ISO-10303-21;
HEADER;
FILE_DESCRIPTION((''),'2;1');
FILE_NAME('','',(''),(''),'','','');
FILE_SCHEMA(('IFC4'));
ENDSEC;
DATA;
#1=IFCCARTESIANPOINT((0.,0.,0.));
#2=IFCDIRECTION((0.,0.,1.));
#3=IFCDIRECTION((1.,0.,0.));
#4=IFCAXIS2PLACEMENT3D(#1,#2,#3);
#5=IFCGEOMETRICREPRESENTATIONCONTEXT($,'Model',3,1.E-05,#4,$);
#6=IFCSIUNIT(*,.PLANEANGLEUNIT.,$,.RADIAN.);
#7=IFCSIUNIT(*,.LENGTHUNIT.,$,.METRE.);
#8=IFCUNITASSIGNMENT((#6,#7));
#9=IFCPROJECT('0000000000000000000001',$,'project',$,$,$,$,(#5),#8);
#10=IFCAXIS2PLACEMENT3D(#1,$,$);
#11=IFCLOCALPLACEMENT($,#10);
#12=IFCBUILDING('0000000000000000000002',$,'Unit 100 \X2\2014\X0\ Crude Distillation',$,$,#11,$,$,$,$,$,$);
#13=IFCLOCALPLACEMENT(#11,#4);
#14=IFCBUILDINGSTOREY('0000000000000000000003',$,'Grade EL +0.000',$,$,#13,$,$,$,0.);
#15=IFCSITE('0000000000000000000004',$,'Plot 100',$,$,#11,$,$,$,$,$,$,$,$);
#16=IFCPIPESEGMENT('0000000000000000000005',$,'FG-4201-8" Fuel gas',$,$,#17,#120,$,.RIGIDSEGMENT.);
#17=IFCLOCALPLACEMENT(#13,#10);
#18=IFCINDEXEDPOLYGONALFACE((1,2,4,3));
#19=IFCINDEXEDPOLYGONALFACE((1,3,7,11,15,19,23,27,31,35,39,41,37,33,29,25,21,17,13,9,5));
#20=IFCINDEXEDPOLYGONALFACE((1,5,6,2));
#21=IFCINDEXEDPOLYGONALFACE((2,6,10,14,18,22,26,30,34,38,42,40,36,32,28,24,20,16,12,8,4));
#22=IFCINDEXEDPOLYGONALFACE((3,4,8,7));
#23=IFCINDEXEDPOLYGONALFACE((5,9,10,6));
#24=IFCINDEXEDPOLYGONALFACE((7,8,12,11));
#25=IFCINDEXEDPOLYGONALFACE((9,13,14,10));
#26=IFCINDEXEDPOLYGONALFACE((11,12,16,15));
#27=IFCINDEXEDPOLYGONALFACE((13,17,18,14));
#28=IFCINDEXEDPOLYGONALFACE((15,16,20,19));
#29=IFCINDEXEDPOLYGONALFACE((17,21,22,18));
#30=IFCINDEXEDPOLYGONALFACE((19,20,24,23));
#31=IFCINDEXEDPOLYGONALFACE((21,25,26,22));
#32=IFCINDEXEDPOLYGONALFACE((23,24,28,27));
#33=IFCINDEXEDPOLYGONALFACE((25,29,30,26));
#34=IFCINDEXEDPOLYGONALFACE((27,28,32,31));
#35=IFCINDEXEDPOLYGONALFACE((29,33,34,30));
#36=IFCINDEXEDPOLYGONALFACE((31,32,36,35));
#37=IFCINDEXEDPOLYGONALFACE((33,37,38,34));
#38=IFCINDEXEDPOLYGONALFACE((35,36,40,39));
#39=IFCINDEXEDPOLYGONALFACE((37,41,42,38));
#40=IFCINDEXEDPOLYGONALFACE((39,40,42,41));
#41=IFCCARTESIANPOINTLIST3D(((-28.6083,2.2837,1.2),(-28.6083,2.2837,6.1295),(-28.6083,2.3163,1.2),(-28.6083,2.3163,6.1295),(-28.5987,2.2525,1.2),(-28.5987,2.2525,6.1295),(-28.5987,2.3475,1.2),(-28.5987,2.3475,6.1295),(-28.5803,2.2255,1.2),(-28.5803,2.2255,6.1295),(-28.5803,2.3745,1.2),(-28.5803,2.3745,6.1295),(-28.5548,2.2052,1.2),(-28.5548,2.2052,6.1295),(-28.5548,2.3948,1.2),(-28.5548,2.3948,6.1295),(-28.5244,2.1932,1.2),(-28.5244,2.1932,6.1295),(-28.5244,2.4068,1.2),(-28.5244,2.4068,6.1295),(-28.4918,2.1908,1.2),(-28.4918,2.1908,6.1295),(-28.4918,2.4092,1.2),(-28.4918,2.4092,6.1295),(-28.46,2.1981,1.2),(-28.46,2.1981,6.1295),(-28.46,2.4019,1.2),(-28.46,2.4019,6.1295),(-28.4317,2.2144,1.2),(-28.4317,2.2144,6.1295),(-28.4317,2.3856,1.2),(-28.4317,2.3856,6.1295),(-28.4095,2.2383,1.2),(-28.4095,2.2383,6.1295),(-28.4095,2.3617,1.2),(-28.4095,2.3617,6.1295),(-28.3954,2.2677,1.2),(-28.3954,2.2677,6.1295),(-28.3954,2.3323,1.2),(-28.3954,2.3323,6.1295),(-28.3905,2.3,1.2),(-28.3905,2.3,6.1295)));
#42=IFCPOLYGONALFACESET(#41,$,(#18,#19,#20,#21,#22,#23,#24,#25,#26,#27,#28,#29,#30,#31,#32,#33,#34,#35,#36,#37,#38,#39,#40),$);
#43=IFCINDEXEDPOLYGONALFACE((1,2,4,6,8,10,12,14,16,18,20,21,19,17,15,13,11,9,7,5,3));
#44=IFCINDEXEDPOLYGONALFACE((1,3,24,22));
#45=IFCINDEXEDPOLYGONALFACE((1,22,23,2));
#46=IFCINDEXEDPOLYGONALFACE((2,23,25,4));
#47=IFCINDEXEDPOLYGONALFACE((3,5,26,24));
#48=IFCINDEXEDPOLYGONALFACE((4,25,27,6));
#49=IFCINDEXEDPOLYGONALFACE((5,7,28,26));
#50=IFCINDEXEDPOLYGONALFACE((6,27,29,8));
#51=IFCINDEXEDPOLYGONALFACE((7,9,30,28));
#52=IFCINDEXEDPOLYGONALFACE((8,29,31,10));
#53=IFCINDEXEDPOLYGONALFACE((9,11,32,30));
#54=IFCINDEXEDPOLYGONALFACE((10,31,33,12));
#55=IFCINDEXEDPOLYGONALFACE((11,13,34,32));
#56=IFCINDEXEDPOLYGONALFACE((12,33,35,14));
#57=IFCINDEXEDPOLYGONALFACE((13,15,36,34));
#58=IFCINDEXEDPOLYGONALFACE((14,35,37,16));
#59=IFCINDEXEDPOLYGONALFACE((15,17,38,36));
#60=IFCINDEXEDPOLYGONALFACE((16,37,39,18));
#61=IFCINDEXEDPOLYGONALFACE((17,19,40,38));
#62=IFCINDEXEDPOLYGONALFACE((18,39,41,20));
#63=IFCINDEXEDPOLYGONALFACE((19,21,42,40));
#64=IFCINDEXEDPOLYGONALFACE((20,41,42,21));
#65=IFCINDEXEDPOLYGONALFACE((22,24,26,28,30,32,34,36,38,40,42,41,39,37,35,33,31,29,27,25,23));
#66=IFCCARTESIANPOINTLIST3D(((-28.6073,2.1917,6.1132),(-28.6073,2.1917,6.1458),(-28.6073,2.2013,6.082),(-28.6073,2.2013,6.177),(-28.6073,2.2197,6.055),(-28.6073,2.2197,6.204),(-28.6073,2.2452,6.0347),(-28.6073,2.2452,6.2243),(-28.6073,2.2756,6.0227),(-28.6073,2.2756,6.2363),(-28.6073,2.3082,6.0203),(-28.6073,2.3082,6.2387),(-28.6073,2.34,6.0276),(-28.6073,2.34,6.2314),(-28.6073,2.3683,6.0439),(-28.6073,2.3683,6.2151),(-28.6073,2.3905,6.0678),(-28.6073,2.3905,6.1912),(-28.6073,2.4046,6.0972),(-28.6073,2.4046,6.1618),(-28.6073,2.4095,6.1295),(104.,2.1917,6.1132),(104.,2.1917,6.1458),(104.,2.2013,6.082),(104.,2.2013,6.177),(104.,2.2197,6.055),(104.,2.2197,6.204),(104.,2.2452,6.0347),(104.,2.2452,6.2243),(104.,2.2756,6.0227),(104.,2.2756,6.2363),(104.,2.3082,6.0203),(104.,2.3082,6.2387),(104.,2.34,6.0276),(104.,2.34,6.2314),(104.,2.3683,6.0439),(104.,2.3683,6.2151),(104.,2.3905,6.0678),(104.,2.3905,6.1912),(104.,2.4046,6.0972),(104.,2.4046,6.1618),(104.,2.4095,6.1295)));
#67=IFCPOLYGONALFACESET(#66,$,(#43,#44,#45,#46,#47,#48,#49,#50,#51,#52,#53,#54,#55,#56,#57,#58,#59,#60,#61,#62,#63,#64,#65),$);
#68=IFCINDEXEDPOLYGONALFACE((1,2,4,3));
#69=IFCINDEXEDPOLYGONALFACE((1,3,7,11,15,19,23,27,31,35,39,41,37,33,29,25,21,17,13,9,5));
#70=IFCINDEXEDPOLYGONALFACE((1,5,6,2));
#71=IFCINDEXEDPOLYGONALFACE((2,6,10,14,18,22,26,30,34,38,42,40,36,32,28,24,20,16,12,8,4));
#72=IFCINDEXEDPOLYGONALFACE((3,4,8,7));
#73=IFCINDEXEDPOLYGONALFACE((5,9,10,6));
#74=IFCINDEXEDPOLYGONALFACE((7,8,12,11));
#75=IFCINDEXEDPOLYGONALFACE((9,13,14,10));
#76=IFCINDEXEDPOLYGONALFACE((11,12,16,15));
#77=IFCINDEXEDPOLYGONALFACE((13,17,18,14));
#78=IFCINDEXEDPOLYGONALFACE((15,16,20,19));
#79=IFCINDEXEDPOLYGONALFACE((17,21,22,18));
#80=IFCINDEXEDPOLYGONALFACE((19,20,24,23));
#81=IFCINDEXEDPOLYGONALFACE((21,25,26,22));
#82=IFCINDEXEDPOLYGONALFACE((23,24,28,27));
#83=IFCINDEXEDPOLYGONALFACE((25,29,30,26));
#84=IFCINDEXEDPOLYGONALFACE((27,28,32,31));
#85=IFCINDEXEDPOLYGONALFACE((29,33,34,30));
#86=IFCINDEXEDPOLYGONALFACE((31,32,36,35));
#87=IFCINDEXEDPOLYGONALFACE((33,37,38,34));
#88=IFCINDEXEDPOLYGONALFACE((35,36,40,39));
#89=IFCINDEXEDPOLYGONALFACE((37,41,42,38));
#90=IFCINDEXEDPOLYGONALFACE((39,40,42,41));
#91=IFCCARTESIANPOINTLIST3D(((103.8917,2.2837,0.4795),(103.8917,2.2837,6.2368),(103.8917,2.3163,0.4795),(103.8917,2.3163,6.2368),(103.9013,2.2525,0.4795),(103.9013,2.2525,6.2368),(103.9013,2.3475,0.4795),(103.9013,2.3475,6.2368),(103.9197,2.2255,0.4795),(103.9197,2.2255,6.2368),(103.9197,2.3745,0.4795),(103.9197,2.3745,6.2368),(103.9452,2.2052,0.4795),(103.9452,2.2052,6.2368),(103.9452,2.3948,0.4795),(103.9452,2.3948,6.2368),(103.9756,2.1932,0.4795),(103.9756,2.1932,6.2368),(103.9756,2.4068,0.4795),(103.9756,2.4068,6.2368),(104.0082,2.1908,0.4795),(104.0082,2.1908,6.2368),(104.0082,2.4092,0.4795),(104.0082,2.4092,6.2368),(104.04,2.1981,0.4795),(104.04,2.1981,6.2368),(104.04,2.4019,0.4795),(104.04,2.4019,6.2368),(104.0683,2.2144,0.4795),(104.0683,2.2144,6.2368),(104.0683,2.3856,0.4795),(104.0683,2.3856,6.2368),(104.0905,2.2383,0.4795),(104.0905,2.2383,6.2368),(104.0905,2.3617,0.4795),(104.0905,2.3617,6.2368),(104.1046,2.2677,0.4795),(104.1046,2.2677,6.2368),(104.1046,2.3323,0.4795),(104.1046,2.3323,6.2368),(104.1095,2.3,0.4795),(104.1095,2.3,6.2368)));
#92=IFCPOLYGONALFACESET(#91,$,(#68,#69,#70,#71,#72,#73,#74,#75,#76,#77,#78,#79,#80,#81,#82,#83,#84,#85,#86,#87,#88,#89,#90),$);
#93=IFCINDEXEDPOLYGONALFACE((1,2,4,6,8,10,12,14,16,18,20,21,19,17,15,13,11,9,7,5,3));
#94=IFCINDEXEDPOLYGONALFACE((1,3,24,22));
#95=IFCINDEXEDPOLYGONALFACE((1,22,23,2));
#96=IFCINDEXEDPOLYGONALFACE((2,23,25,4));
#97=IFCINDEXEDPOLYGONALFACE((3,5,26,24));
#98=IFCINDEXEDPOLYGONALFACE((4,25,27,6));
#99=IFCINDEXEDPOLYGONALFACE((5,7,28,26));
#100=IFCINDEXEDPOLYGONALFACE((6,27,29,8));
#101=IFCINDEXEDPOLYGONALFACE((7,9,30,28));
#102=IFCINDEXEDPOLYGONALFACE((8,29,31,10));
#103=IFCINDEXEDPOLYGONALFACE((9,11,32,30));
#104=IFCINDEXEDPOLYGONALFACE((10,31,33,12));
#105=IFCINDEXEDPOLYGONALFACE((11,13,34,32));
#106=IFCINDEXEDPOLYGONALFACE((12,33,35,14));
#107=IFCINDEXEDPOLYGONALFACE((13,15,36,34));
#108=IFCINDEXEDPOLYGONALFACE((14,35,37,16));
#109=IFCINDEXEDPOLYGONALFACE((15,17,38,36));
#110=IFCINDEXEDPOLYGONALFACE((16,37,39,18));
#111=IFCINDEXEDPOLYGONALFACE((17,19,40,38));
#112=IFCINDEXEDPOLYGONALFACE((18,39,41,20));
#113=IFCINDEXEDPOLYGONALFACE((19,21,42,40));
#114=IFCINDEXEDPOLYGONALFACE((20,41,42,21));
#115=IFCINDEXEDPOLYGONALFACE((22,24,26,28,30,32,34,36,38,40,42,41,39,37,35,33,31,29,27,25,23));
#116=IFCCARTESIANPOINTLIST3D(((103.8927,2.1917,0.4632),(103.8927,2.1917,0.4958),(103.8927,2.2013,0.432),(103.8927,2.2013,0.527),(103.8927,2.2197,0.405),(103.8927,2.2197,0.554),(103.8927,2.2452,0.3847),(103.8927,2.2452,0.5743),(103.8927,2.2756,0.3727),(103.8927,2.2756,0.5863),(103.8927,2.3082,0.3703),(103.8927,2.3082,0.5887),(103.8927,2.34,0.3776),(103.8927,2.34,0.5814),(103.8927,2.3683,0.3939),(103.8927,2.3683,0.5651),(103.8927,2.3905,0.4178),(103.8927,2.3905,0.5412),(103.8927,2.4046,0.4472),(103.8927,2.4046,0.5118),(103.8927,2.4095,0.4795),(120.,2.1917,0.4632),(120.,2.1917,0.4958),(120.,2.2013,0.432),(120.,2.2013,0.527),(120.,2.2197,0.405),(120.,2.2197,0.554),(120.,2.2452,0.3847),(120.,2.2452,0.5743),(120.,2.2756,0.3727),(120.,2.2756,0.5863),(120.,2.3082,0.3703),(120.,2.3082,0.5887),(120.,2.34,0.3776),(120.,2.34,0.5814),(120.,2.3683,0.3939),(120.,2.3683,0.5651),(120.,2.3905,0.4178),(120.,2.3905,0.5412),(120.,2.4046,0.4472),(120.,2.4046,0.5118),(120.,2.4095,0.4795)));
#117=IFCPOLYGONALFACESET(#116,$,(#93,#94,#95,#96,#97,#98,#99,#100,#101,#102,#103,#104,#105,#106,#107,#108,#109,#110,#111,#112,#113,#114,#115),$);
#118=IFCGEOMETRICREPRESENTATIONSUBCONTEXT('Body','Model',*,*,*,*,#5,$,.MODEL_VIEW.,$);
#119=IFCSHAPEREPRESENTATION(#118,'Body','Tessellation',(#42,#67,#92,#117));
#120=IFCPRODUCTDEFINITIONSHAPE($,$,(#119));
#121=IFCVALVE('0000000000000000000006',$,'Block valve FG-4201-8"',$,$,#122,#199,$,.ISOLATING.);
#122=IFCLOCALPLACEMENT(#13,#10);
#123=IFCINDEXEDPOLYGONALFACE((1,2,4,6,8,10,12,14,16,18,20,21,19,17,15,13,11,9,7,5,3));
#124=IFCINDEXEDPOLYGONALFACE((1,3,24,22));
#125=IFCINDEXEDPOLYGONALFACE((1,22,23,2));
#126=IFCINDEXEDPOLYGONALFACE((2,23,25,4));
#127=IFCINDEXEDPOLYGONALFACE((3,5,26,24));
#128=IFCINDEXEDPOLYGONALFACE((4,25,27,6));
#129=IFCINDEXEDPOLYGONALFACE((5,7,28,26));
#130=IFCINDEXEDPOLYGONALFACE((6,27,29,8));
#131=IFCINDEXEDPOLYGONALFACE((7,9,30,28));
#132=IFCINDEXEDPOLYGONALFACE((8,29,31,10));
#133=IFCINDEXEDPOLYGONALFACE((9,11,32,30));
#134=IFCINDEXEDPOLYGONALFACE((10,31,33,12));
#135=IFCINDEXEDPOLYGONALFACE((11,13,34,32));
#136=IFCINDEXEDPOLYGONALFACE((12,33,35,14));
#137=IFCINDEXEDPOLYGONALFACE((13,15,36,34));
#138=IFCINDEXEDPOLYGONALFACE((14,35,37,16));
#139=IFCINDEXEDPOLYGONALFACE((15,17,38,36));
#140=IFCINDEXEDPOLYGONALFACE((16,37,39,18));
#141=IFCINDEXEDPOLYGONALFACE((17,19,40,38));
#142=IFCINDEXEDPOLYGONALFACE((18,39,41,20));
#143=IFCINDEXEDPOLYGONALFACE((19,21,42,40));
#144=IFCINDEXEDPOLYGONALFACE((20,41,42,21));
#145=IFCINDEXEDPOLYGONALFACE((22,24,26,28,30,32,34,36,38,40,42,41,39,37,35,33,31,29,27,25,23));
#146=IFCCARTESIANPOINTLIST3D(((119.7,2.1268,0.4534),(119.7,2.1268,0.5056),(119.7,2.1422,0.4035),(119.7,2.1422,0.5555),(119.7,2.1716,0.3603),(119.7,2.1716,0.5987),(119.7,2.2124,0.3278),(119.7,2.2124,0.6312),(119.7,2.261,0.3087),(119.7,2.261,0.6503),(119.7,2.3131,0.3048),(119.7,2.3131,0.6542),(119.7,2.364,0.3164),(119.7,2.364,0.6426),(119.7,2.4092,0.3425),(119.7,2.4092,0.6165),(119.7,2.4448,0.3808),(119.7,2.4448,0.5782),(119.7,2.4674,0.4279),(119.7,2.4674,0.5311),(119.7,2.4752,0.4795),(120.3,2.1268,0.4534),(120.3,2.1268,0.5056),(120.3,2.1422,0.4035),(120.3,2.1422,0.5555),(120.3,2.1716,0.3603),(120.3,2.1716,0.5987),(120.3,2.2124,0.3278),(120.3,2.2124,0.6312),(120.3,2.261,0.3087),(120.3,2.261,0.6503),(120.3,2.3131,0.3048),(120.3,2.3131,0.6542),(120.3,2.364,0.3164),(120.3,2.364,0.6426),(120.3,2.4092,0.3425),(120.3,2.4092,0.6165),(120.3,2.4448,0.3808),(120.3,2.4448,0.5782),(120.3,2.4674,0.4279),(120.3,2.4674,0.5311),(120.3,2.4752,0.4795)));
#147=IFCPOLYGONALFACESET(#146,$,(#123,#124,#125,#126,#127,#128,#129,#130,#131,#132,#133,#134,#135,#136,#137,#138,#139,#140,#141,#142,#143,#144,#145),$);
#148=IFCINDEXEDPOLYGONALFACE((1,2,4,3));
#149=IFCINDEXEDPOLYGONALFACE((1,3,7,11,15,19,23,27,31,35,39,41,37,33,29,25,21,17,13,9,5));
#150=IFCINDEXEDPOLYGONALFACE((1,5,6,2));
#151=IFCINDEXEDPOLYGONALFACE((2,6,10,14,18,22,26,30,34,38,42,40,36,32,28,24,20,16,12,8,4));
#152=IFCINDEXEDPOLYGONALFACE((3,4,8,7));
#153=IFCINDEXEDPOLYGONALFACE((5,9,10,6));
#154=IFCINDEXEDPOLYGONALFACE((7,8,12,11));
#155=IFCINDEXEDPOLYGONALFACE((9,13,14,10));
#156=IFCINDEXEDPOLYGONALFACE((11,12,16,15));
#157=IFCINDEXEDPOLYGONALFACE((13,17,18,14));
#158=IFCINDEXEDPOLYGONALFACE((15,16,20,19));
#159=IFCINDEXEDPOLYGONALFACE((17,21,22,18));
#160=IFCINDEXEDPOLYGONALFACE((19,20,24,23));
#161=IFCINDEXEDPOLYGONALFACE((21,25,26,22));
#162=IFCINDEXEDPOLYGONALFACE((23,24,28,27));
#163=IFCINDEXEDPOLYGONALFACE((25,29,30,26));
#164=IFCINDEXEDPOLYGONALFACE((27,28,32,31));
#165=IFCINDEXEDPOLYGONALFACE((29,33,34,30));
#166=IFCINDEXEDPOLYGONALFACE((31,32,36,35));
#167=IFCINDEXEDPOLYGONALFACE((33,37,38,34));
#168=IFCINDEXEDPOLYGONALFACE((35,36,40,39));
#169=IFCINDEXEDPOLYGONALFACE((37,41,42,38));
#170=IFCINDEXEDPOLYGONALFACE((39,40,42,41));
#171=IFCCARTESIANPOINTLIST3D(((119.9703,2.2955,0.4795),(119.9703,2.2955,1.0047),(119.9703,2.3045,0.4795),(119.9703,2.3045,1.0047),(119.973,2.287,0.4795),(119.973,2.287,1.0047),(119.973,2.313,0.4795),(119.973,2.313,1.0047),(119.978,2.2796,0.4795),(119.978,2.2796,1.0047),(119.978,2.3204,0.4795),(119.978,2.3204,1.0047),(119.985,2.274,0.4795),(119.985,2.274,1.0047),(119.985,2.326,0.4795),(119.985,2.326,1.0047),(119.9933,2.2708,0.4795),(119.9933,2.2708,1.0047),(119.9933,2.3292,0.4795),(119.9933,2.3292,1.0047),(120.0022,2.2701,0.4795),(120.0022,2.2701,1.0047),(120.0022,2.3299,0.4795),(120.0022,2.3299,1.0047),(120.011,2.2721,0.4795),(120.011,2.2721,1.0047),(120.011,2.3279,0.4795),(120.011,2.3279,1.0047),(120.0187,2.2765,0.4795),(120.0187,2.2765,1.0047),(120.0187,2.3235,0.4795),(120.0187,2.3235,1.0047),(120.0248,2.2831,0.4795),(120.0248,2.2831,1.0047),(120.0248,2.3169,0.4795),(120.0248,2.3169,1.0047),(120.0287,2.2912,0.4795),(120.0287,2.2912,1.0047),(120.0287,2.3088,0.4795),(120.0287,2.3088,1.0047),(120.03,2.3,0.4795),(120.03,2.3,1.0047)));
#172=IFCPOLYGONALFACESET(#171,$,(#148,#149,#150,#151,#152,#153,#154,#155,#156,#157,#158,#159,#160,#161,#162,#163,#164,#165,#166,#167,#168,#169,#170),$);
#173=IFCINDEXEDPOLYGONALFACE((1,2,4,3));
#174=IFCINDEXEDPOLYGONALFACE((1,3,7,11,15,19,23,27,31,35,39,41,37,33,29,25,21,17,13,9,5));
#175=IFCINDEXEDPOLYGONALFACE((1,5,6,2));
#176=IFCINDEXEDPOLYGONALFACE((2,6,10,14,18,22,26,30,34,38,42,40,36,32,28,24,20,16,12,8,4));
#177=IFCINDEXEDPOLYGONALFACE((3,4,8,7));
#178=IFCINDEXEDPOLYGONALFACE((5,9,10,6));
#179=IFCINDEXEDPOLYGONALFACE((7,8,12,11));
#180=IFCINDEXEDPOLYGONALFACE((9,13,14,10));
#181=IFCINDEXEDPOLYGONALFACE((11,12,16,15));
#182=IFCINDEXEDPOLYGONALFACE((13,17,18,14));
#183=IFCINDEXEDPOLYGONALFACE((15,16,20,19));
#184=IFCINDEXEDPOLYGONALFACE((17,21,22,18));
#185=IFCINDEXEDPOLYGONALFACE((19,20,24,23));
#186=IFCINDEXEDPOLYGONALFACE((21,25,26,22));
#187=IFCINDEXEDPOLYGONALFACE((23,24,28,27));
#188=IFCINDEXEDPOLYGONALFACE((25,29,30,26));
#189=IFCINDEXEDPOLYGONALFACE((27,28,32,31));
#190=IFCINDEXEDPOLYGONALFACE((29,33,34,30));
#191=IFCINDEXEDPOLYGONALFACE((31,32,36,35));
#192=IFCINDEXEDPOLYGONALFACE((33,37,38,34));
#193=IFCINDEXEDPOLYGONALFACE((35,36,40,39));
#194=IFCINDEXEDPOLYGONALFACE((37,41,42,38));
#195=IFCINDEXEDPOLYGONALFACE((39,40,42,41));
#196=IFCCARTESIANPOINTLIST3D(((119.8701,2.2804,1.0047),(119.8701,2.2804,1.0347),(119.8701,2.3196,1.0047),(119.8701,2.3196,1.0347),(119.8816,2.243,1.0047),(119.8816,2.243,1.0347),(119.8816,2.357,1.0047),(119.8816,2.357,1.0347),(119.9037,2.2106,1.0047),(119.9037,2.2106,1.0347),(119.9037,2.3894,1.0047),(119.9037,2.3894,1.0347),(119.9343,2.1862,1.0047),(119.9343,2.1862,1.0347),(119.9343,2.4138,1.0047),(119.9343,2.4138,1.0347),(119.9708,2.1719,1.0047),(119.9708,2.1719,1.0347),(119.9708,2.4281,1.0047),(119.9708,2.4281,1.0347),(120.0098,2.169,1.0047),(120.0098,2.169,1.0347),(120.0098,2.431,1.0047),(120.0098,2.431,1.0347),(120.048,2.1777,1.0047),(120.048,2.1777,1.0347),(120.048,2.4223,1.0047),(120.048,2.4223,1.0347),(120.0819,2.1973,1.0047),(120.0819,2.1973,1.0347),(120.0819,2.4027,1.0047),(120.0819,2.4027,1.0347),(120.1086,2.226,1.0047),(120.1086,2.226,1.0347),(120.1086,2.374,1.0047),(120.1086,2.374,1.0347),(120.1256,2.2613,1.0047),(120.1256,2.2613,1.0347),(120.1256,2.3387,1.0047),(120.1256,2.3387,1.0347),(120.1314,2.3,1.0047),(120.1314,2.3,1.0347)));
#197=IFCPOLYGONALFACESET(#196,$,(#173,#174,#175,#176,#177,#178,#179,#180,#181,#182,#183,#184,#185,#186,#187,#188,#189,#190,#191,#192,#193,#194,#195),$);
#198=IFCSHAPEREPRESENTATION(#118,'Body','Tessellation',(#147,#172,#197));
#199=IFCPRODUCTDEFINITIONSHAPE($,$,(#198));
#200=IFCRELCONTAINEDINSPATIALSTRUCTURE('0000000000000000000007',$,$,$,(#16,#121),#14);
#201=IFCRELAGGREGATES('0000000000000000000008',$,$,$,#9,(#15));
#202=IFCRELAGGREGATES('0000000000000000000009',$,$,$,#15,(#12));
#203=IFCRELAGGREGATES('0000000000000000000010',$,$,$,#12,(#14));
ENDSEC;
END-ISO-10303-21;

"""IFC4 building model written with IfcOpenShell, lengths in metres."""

from ifc_helpers import new_model, si_unit, frame, origin, origin_with_axes, origin_2d, place, context, subcontext, project, spatial, circle, extrude, element, save


model = new_model("IFC4")

# Units and contexts
model_context = context("Model", 3, precision=1e-05, world=origin_with_axes())
body_context = subcontext(model_context, "Body", "Model", "MODEL_VIEW")
ifc_project = project(units=[si_unit("PLANEANGLEUNIT", "RADIAN"), si_unit("LENGTHUNIT", "METRE")], contexts=[model_context])

# Site, building, storey
placement = place(None, origin())
site = spatial("IfcSite", under=ifc_project, at=placement, Name="Plot 100")
building = spatial("IfcBuilding", under=site, at=placement, Name="Unit 100 — Crude Distillation")
storey_placement = place(placement, origin_with_axes())
storey = spatial("IfcBuildingStorey", under=building, at=storey_placement, Name="Grade EL +0.000", Elevation=0.0)

# Pipe segment
pipe_segment_1_placement = place(storey_placement, origin_with_axes())
element("IfcPipeSegment", 1, at=pipe_segment_1_placement, inside=storey, Name="FG-4201-8\" Fuel gas", PredefinedType="RIGIDSEGMENT", context=body_context, shape_type="SweptSolid", body=[
    extrude(circle(Radius=0.1095, at=origin_2d()), frame((-28.5, 2.3, 1.2), z_axis=(0.0, 0.0, 1.0), x_axis=(1.0, 0.0, 0.0)), (0.0, 0.0, 1.0), 4.9295),
    extrude(circle(Radius=0.1095, at=origin_2d()), frame((-28.6073, 2.3, 6.1295), z_axis=(1.0, 0.0, 0.0), x_axis=(0.0, 1.0, 0.0)), (0.0, 0.0, 1.0), 132.6073),
    extrude(circle(Radius=0.1095, at=origin_2d()), frame((104.0, 2.3, 6.2368), z_axis=(0.0, 0.0, -1.0), x_axis=(1.0, 0.0, 0.0)), (0.0, 0.0, 1.0), 5.7573),
    extrude(circle(Radius=0.1095, at=origin_2d()), frame((103.8927, 2.3, 0.4795), z_axis=(1.0, 0.0, 0.0), x_axis=(0.0, 1.0, 0.0)), (0.0, 0.0, 1.0), 16.1073),
])

# Valve
valve_1_placement = place(storey_placement, origin_with_axes())
element("IfcValve", 2, at=valve_1_placement, inside=storey, Name="Block valve FG-4201-8\"", PredefinedType="ISOLATING", context=body_context, shape_type="SweptSolid", body=[
    extrude(circle(Radius=0.1752, at=origin_2d()), frame((119.7, 2.3, 0.4795), z_axis=(1.0, 0.0, 0.0), x_axis=(0.0, 1.0, 0.0)), (0.0, 0.0, 1.0), 0.6),
    extrude(circle(Radius=0.03, at=origin_2d()), frame((120.0, 2.3, 0.4795), z_axis=(0.0, 0.0, 1.0), x_axis=(1.0, 0.0, 0.0)), (0.0, 0.0, 1.0), 0.5252),
    extrude(circle(Radius=0.1314, at=origin_2d()), frame((120.0, 2.3, 1.0047), z_axis=(0.0, 0.0, 1.0), x_axis=(1.0, 0.0, 0.0)), (0.0, 0.0, 1.0), 0.03),
])

save(model, "model.ifc")
